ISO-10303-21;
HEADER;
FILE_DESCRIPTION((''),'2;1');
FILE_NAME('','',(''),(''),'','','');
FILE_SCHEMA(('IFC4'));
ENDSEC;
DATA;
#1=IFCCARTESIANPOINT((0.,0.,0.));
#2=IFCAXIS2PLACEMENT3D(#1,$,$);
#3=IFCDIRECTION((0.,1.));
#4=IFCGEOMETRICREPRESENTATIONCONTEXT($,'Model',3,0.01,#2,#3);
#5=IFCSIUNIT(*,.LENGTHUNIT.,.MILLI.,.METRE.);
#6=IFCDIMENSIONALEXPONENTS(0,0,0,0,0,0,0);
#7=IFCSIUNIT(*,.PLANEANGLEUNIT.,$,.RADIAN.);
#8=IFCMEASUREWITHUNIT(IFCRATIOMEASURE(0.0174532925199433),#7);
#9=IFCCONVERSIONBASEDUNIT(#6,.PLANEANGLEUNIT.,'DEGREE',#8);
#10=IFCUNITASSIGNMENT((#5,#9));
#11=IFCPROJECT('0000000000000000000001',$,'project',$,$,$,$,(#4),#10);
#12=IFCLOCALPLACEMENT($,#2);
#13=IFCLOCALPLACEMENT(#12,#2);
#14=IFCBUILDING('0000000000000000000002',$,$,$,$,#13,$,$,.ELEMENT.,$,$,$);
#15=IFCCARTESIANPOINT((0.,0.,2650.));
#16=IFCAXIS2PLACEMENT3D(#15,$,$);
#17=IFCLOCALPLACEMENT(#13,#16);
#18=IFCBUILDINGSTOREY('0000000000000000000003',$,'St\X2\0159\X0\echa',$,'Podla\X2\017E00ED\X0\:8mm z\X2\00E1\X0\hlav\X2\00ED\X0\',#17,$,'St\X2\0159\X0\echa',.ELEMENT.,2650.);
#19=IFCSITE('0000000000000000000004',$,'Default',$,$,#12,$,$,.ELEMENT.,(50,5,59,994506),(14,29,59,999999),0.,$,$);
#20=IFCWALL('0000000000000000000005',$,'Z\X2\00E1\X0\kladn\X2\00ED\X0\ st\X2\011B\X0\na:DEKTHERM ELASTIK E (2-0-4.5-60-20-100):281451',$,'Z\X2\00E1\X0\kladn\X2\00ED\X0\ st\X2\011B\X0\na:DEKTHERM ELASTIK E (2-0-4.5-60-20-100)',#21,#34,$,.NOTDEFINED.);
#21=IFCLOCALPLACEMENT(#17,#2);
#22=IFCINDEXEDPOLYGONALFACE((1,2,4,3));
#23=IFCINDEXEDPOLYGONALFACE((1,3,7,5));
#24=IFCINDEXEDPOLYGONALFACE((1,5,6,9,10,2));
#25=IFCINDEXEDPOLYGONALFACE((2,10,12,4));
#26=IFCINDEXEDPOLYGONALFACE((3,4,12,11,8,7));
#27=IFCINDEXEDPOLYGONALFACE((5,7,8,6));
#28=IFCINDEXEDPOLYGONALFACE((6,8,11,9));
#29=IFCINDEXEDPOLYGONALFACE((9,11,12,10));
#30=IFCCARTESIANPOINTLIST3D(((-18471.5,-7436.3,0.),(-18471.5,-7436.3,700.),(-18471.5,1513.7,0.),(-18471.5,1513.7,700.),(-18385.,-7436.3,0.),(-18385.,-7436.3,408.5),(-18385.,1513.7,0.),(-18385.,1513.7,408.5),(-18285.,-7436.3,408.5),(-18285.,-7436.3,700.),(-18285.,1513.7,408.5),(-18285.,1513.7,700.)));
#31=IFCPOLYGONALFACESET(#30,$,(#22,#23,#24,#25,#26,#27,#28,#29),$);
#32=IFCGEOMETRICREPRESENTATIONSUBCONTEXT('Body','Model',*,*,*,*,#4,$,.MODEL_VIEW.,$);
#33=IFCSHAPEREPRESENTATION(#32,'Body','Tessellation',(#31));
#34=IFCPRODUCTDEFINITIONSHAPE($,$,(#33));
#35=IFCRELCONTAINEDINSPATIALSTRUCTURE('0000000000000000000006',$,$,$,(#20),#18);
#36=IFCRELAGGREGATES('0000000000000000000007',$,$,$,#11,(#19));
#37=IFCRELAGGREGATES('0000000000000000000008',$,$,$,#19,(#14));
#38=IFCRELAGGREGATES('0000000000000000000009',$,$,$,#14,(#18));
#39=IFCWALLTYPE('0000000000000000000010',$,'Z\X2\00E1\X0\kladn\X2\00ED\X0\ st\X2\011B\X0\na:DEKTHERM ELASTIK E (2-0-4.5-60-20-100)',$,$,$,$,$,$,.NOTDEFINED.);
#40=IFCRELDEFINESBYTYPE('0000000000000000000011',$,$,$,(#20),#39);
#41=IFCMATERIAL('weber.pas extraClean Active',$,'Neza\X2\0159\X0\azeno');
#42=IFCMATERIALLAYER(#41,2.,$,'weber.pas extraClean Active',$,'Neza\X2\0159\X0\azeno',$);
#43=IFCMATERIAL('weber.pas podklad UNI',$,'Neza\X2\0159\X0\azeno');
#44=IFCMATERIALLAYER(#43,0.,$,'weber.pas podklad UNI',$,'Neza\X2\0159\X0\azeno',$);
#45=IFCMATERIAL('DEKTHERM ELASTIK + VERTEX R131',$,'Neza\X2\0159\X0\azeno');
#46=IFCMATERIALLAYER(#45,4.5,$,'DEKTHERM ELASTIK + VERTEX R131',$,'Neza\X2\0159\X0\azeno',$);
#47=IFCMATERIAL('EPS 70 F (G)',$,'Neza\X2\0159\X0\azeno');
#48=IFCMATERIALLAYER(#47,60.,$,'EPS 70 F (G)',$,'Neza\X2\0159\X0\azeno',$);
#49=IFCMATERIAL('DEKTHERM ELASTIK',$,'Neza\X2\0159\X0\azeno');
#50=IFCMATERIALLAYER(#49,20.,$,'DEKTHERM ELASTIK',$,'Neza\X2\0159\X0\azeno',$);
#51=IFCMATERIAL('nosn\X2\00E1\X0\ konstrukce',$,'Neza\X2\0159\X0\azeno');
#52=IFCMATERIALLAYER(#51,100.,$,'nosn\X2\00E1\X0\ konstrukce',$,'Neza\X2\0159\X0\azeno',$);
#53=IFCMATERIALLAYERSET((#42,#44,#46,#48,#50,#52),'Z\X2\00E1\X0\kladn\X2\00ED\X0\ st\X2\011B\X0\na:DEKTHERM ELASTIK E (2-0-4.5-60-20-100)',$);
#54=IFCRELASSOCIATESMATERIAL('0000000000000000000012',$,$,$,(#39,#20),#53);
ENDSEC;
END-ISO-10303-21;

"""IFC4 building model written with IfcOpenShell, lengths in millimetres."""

from ifc_helpers import new_model, entity, si_unit, converted_unit, direction, frame, frame_2d, origin, place, context, subcontext, project, spatial, polyline, rectangle, extrude, clip, halfspace, bounded_halfspace, material, layer, layer_set, layer_usage, type_object, element, save


model = new_model("IFC4")

# Units and contexts
model_context = context("Model", 3, precision=0.01, world=origin(), true_north=direction((0.0, 1.0)))
body_context = subcontext(model_context, "Body", "Model", "MODEL_VIEW")
ifc_project = project(units=[si_unit("LENGTHUNIT", "METRE", prefix="MILLI"), converted_unit("PLANEANGLEUNIT", "DEGREE", entity("IfcRatioMeasure", 0.0174532925199433), si_unit("PLANEANGLEUNIT", "RADIAN"), dimensions=[0, 0, 0, 0, 0, 0, 0])], contexts=[model_context])

# Site, building, storey
site_placement = place(None, origin())
site = spatial("IfcSite", under=ifc_project, at=site_placement, Name="Default", CompositionType="ELEMENT", RefLatitude=(50, 5, 59, 994506), RefLongitude=(14, 29, 59, 999999), RefElevation=0.0)
building_placement = place(site_placement, origin())
building = spatial("IfcBuilding", under=site, at=building_placement, CompositionType="ELEMENT")
storey_placement = place(building_placement, frame((0.0, 0.0, 2650.0)))
storey = spatial("IfcBuildingStorey", under=building, at=storey_placement, Name="Střecha", ObjectType="Podlaží:8mm záhlaví", LongName="Střecha", CompositionType="ELEMENT", Elevation=2650.0)

# Wall
ifc_material_1 = material(Name="weber.pas extraClean Active", Category="Nezařazeno")
ifc_layer_1 = layer(ifc_material_1, 2.0, Name="weber.pas extraClean Active", Category="Nezařazeno")
ifc_material_2 = material(Name="weber.pas podklad UNI", Category="Nezařazeno")
ifc_layer_2 = layer(ifc_material_2, 0.0, Name="weber.pas podklad UNI", Category="Nezařazeno")
ifc_material_3 = material(Name="DEKTHERM ELASTIK + VERTEX R131", Category="Nezařazeno")
ifc_layer_3 = layer(ifc_material_3, 4.5, Name="DEKTHERM ELASTIK + VERTEX R131", Category="Nezařazeno")
ifc_material_4 = material(Name="EPS 70 F (G)", Category="Nezařazeno")
ifc_layer_4 = layer(ifc_material_4, 60.0, Name="EPS 70 F (G)", Category="Nezařazeno")
ifc_material_5 = material(Name="DEKTHERM ELASTIK", Category="Nezařazeno")
ifc_layer_5 = layer(ifc_material_5, 20.0, Name="DEKTHERM ELASTIK", Category="Nezařazeno")
ifc_material_6 = material(Name="nosná konstrukce", Category="Nezařazeno")
ifc_layer_6 = layer(ifc_material_6, 100.0, Name="nosná konstrukce", Category="Nezařazeno")
ifc_layer_set_1 = layer_set([ifc_layer_1, ifc_layer_2, ifc_layer_3, ifc_layer_4, ifc_layer_5, ifc_layer_6], Name="Základní stěna:DEKTHERM ELASTIK E (2-0-4.5-60-20-100)")
ifc_layer_usage = layer_usage(ifc_layer_set_1, "AXIS2", "POSITIVE", -93.2)
wall_type = type_object("IfcWallType", Name="Základní stěna:DEKTHERM ELASTIK E (2-0-4.5-60-20-100)", PredefinedType="NOTDEFINED", material=ifc_layer_set_1)
wall_placement = place(storey_placement, frame((-18378.2, 1513.7, 0.0), z_axis=(0.0, 0.0, 1.0), x_axis=(0.0, -1.0, 0.0)))
element("IfcWall", 1, at=wall_placement, inside=storey, type_object=wall_type, material=ifc_layer_usage, Name="Základní stěna:DEKTHERM ELASTIK E (2-0-4.5-60-20-100):281451", ObjectType="Základní stěna:DEKTHERM ELASTIK E (2-0-4.5-60-20-100)", PredefinedType="NOTDEFINED", context=body_context, shape_type="Clipping", body=[
    clip(clip(clip(extrude(rectangle(XDim=8950.0, YDim=186.5, at=frame_2d((4475.0, 0.0), x_axis=(-1.0, 0.0))), origin(), (0.0, 0.0, 1.0), 700.0), bounded_halfspace(frame((8950.0, -6.8, 408.5), z_axis=(0.0, 0.0, 1.0), x_axis=(0.0, 1.0, 0.0)), True, frame((8950.0, -6.8, 408.5), z_axis=(0.0, 0.0, 1.0), x_axis=(0.0, 1.0, 0.0)), polyline([(0.0, 0.0), (100.0, 0.0), (100.0, 8950.0), (0.0, 8950.0), (0.0, 0.0)]))), bounded_halfspace(frame((0.0, -6.8, 408.5), z_axis=(0.0, -1.0, 0.0), x_axis=(1.0, 0.0, 0.0)), True, frame((0.0, -6.8, 408.5), z_axis=(0.0, -1.0, 0.0), x_axis=(1.0, 0.0, 0.0)), polyline([(0.0, 0.0), (0.0, -408.5), (8950.0, -408.5), (8950.0, 0.0), (0.0, 0.0)]))), halfspace(frame((0.0, 0.0, -2650.0)), True)),
])

save(model, "model.ifc")
